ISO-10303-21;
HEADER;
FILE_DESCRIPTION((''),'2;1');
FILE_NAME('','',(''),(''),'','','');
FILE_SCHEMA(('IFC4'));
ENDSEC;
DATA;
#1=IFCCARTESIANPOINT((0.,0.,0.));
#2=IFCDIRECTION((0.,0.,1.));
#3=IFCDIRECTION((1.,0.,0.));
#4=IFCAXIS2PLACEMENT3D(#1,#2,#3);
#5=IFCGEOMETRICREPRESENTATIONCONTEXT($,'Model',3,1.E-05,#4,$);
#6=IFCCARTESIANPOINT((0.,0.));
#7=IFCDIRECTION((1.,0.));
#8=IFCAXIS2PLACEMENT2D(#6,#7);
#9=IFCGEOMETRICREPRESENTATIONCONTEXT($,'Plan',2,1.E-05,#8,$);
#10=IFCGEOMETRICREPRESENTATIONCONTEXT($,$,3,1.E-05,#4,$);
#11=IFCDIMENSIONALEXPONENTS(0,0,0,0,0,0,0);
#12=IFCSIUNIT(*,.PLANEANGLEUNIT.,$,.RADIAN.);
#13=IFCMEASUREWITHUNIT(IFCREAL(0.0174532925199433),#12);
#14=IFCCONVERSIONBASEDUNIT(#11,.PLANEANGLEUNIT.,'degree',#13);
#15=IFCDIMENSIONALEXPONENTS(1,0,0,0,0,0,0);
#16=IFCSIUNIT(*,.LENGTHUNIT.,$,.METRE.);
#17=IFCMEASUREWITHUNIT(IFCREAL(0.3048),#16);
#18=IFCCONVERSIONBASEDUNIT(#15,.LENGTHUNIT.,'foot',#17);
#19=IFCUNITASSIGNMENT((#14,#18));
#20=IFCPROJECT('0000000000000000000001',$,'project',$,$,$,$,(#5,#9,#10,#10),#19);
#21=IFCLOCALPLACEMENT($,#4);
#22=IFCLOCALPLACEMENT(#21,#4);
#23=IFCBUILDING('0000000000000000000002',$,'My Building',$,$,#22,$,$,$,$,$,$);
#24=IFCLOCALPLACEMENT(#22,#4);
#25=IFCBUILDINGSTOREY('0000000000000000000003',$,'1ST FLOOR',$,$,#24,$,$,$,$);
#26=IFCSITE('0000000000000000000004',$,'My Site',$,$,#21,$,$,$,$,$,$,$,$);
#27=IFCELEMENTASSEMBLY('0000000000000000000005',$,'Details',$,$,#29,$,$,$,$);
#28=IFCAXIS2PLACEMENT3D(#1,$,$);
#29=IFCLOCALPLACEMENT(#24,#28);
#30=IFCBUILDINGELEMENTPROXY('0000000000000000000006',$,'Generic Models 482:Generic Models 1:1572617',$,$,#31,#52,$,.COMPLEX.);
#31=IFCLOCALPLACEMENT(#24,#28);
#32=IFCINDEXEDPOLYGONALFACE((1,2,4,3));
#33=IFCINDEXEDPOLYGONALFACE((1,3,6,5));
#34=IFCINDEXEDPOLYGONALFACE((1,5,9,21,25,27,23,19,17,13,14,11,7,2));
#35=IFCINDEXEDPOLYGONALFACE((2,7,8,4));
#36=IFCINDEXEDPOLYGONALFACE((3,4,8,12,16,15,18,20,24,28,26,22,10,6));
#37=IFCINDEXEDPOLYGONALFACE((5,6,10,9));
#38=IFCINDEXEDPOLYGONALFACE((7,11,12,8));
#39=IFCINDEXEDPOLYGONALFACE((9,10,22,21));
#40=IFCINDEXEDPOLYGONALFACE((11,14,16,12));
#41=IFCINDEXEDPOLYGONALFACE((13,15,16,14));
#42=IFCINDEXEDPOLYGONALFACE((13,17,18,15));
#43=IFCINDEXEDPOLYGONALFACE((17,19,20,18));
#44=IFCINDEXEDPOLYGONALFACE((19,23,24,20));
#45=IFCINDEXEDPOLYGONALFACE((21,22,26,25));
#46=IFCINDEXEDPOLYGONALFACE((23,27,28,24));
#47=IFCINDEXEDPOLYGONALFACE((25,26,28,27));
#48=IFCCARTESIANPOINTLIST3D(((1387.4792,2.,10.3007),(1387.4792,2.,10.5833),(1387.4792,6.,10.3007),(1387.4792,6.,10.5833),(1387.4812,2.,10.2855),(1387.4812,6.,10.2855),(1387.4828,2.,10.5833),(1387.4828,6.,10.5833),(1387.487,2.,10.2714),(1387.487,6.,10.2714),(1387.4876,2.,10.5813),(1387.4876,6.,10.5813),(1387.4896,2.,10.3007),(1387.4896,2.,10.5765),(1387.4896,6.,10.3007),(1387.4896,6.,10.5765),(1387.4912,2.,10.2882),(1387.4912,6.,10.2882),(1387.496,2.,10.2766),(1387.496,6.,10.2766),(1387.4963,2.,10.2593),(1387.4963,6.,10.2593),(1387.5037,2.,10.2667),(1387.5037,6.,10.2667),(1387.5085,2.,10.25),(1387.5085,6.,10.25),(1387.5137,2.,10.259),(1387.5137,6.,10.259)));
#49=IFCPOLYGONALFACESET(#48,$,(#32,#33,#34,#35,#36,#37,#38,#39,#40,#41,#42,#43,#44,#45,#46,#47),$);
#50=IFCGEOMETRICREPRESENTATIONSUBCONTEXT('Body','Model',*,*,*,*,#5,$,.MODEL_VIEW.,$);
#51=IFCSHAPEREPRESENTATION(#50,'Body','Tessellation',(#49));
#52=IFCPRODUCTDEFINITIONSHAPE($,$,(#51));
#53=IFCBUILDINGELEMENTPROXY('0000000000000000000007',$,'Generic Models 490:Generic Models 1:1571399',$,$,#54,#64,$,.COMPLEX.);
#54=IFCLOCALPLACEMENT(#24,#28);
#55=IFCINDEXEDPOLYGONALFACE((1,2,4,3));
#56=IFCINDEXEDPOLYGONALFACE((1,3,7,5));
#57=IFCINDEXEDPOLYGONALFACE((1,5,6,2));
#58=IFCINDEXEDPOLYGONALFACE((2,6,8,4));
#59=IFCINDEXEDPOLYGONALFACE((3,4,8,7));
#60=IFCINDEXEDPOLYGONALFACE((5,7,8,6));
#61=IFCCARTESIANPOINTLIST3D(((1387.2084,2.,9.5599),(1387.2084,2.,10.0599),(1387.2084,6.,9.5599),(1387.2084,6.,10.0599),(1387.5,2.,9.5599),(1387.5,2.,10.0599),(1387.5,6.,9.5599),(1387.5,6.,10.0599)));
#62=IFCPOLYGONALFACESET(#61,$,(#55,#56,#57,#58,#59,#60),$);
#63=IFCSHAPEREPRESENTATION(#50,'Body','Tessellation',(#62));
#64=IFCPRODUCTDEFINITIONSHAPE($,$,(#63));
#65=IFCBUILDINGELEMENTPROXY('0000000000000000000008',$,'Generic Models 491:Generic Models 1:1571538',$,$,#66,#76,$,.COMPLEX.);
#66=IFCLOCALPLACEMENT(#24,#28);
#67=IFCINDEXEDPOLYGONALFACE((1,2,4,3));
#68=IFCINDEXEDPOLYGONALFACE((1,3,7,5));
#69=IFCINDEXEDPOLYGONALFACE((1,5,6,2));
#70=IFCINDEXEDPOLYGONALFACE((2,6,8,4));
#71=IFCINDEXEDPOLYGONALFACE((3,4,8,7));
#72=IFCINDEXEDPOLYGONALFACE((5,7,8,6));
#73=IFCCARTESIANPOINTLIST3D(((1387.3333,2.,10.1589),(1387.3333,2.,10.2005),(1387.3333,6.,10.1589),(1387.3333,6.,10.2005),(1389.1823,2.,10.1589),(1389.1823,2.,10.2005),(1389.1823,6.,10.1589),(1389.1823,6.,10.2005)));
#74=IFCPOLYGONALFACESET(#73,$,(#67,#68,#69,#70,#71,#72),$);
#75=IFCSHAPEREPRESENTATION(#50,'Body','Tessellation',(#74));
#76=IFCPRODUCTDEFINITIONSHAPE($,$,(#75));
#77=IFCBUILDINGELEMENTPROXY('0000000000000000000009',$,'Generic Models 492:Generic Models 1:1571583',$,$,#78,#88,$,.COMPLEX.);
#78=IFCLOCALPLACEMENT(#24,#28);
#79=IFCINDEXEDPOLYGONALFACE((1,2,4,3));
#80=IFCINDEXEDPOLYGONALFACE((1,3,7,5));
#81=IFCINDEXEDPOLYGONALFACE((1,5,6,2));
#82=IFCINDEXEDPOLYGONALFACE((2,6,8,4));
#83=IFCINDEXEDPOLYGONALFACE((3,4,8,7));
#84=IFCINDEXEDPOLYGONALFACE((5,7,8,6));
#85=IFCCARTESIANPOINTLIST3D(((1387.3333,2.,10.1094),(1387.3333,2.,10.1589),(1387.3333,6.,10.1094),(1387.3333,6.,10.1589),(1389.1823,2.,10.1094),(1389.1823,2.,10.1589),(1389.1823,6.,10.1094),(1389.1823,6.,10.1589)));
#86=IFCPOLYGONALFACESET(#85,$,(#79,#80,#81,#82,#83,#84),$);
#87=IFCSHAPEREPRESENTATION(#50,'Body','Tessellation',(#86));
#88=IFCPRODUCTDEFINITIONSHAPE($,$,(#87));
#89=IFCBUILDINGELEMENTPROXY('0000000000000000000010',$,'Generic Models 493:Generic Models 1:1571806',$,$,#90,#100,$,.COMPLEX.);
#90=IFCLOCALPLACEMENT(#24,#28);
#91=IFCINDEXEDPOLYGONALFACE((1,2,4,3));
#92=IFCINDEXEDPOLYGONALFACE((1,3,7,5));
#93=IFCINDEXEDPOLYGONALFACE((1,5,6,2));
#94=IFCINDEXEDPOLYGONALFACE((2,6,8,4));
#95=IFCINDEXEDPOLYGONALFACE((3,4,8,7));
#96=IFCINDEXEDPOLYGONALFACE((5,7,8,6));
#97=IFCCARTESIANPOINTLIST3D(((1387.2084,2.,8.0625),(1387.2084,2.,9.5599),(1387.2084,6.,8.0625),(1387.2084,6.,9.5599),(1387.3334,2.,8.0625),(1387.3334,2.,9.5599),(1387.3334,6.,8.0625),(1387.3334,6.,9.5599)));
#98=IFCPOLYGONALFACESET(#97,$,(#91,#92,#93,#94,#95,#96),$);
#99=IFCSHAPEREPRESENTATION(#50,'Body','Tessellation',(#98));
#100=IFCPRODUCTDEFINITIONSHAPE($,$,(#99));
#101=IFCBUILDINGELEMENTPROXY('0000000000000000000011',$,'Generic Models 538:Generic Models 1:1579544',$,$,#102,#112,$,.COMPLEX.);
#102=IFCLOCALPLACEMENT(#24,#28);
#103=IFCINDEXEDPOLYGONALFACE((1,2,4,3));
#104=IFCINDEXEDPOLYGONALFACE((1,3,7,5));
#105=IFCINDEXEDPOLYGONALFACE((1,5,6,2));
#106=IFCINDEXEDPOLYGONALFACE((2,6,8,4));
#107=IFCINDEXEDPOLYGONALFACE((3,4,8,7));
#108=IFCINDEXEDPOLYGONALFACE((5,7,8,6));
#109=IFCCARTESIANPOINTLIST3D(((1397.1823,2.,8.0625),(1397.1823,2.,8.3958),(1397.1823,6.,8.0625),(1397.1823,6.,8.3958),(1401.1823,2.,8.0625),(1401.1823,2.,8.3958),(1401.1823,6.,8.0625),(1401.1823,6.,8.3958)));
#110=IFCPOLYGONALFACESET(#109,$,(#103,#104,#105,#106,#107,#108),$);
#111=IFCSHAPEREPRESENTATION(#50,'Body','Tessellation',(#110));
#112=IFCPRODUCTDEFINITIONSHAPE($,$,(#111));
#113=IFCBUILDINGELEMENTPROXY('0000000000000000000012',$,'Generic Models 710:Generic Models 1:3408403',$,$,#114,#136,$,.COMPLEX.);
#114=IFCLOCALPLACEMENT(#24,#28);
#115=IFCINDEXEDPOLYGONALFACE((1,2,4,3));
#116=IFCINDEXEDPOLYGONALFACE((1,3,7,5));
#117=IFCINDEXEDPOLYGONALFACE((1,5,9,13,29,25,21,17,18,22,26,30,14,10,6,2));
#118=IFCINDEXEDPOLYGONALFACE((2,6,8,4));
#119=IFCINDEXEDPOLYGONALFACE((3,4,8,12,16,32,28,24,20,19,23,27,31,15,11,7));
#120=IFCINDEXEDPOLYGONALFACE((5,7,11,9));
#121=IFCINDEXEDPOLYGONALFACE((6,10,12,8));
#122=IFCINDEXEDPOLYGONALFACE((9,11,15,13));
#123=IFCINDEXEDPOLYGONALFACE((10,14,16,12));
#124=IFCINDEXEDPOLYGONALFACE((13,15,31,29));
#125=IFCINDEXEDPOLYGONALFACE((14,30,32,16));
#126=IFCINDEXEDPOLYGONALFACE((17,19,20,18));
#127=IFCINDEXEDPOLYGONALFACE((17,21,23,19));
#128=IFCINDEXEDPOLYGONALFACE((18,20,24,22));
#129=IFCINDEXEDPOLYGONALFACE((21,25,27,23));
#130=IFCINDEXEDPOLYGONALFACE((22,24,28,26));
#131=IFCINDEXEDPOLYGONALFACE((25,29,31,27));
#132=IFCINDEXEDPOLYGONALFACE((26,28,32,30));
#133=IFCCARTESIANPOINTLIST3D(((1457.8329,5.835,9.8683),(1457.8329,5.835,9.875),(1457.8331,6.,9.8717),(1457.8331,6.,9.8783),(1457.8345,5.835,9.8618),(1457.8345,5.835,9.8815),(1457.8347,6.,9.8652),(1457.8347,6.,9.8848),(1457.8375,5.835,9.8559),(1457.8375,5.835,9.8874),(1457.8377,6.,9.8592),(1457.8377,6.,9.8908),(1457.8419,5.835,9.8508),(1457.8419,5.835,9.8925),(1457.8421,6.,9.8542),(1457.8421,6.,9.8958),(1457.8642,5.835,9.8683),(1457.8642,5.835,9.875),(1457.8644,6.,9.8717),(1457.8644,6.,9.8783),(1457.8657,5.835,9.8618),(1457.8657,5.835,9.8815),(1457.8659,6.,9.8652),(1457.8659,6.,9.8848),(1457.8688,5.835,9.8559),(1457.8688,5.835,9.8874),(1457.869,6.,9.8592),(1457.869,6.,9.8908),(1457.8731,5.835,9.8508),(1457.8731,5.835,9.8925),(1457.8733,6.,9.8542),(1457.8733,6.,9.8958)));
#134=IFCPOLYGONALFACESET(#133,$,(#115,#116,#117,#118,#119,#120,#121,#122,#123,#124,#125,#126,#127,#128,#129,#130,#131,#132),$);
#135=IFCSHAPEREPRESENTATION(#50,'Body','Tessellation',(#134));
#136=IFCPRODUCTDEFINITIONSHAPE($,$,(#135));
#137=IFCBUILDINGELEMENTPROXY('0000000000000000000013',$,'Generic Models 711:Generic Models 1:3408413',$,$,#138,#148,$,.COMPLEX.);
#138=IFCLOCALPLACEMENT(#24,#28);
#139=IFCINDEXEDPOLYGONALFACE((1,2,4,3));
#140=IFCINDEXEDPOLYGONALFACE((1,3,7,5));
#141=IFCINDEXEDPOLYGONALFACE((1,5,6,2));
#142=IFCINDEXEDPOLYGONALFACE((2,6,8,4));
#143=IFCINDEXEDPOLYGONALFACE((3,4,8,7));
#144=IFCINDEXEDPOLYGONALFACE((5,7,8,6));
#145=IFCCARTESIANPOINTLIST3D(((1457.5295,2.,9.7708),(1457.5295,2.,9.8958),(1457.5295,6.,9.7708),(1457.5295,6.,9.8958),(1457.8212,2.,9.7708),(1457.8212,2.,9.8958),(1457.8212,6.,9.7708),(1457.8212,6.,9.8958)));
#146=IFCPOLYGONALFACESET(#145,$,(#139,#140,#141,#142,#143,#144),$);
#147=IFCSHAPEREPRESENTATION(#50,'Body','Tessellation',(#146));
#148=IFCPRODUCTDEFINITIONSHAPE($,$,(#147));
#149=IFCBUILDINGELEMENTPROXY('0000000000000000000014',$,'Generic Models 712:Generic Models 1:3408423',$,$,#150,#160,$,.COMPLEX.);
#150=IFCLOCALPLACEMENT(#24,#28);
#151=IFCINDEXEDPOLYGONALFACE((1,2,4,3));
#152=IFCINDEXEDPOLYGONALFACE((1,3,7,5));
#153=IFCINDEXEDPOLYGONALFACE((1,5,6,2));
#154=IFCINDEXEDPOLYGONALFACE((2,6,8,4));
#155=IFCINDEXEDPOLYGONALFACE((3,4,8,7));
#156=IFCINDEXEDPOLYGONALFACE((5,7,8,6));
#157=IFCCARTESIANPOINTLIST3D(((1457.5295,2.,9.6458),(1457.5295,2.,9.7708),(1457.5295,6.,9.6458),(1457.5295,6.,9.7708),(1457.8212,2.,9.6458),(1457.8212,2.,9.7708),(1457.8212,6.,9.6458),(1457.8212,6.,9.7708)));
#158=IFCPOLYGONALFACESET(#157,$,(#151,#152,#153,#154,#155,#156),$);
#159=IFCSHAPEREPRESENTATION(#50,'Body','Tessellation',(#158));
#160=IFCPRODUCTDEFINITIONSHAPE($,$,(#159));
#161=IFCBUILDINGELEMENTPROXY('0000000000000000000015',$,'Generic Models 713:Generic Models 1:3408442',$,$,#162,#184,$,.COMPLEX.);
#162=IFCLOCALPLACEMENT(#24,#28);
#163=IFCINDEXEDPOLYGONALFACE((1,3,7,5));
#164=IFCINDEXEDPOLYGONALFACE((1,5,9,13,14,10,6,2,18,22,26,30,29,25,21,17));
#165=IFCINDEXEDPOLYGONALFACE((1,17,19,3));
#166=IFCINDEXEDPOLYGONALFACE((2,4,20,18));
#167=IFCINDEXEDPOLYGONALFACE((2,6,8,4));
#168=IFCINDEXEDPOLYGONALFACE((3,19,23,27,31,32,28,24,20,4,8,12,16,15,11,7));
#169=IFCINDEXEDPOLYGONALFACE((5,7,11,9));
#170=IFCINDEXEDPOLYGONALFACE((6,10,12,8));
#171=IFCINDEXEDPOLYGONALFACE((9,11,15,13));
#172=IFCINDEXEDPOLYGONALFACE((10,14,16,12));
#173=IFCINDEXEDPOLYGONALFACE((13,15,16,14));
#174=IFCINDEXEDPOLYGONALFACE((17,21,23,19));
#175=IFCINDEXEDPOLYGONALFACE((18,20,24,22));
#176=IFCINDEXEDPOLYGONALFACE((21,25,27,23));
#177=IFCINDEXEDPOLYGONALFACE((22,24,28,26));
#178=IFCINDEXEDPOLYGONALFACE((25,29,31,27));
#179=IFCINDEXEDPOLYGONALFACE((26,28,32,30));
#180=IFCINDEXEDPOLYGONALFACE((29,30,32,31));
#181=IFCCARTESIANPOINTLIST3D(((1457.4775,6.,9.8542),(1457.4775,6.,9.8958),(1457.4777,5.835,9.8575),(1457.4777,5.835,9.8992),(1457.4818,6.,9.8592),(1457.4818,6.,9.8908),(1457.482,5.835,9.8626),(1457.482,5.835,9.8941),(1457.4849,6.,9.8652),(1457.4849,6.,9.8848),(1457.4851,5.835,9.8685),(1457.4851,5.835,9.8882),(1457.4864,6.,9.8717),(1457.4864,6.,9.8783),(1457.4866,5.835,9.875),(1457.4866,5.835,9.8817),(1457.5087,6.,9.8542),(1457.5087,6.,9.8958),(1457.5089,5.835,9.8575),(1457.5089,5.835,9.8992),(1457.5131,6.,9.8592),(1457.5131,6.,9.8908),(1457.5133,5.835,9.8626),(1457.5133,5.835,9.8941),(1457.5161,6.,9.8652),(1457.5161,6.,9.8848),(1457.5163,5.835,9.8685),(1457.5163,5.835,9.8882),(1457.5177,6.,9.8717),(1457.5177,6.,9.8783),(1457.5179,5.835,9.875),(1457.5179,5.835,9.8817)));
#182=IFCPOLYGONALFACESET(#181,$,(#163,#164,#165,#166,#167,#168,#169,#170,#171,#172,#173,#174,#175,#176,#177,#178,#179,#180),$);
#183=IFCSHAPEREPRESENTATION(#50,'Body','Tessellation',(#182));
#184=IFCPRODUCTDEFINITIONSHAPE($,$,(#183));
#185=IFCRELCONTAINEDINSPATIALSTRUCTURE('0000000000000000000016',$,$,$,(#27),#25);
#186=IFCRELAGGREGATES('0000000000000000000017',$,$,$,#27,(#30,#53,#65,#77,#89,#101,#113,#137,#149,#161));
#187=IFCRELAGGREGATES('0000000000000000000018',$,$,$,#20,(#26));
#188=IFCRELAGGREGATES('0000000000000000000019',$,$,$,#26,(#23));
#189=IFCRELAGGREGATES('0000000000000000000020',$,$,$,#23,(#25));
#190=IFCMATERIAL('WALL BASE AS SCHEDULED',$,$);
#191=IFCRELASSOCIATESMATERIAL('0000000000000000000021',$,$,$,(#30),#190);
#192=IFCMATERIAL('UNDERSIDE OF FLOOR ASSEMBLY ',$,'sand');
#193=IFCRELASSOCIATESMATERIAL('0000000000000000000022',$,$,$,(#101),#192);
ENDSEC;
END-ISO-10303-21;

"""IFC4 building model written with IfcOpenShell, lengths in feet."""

from ifc_helpers import new_model, entity, si_unit, converted_unit, frame, origin_with_axes, origin_2d_with_axis, place, context, subcontext, project, spatial, polyline, outline, extrude, material, element, aggregate, save


model = new_model("IFC4")

# Units and contexts
model_context = context("Model", 3, precision=1e-05, world=origin_with_axes())
plan_context = context("Plan", 2, precision=1e-05, world=origin_2d_with_axis())
context_of_model = context(None, 3, precision=1e-05, world=origin_with_axes())
body_context = subcontext(model_context, "Body", "Model", "MODEL_VIEW")
ifc_project = project(units=[converted_unit("PLANEANGLEUNIT", "degree", entity("IfcReal", 0.0174532925199433), si_unit("PLANEANGLEUNIT", "RADIAN"), dimensions=[0, 0, 0, 0, 0, 0, 0]), converted_unit("LENGTHUNIT", "foot", entity("IfcReal", 0.3048), si_unit("LENGTHUNIT", "METRE"), dimensions=[1, 0, 0, 0, 0, 0, 0])], contexts=[model_context, plan_context, context_of_model, context_of_model])

# Site, building, storey
site_placement = place(None, origin_with_axes())
site = spatial("IfcSite", under=ifc_project, at=site_placement, Name="My Site")
building_placement = place(site_placement, origin_with_axes())
building = spatial("IfcBuilding", under=site, at=building_placement, Name="My Building")
storey_placement = place(building_placement, origin_with_axes())
storey = spatial("IfcBuildingStorey", under=building, at=storey_placement, Name="1ST FLOOR")

# Element assembly, building element proxies
assembly_placement = place(storey_placement, origin_with_axes())
assembly = element("IfcElementAssembly", 1, at=assembly_placement, inside=storey, Name="Details")
ifc_material_1 = material(Name="WALL BASE AS SCHEDULED")
proxy_1_placement = place(assembly_placement, frame((1387.4792, 6.0, 10.25), z_axis=(0.0, -1.0, 0.0), x_axis=(0.0, 0.0, 1.0)))
proxy_1 = element("IfcBuildingElementProxy", 2, at=proxy_1_placement, material=ifc_material_1, Name="Generic Models 482:Generic Models 1:1572617", PredefinedType="COMPLEX", context=body_context, shape_type="SweptSolid", body=[
    extrude(outline(polyline([(0.2206, 0.0), (0.2204, 0.0036), (0.2182, 0.0083), (0.2132, 0.01), (-0.0621, -0.0058), (-0.0747, -0.0049), (-0.0865, -0.0007), (-0.0969, 0.0063), (-0.1051, 0.0158), (-0.1138, 0.0101), (-0.1038, -0.0014), (-0.0912, -0.01), (-0.0768, -0.0151), (-0.0615, -0.0162), (0.2206, 0.0)])), frame((0.113, -0.0126, 0.0), z_axis=(0.0, 0.0, -1.0), x_axis=(0.998358, 0.057286, 0.0)), (0.0, 0.0, -1.0), 4.0),
])
proxy_2_placement = place(assembly_placement, frame((1387.2084, 6.0, 9.5599), z_axis=(0.0, -1.0, 0.0), x_axis=(0.0, 0.0, 1.0)))
proxy_2 = element("IfcBuildingElementProxy", 3, at=proxy_2_placement, Name="Generic Models 490:Generic Models 1:1571399", PredefinedType="COMPLEX", context=body_context, shape_type="SweptSolid", body=[
    extrude(outline(polyline([(-0.25, -0.1458), (0.25, -0.1458), (0.25, 0.1458), (-0.25, 0.1458), (-0.25, -0.1458)])), frame((0.25, -0.1458, 0.0), z_axis=(0.0, 0.0, -1.0), x_axis=(-1.0, 0.0, 0.0)), (0.0, 0.0, -1.0), 4.0),
])
proxy_3_placement = place(assembly_placement, frame((1387.3333, 6.0, 10.1589), z_axis=(0.0, -1.0, 0.0), x_axis=(0.0, 0.0, 1.0)))
proxy_3 = element("IfcBuildingElementProxy", 4, at=proxy_3_placement, Name="Generic Models 491:Generic Models 1:1571538", PredefinedType="COMPLEX", context=body_context, shape_type="SweptSolid", body=[
    extrude(outline(polyline([(-0.0208, -0.9245), (0.0208, -0.9245), (0.0208, 0.9245), (-0.0208, 0.9245), (-0.0208, -0.9245)])), frame((0.0208, -0.9245, 0.0), z_axis=(0.0, 0.0, -1.0), x_axis=(-1.0, 0.0, 0.0)), (0.0, 0.0, -1.0), 4.0),
])
proxy_4_placement = place(assembly_placement, frame((1387.3333, 6.0, 10.1094), z_axis=(0.0, -1.0, 0.0), x_axis=(0.0, 0.0, 1.0)))
proxy_4 = element("IfcBuildingElementProxy", 5, at=proxy_4_placement, Name="Generic Models 492:Generic Models 1:1571583", PredefinedType="COMPLEX", context=body_context, shape_type="SweptSolid", body=[
    extrude(outline(polyline([(-0.0247, -0.9245), (0.0247, -0.9245), (0.0247, 0.9245), (-0.0247, 0.9245), (-0.0247, -0.9245)])), frame((0.0247, -0.9245, 0.0), z_axis=(0.0, 0.0, -1.0), x_axis=(-1.0, 0.0, 0.0)), (0.0, 0.0, -1.0), 4.0),
])
proxy_5_placement = place(assembly_placement, frame((1387.2084, 6.0, 8.0625), z_axis=(0.0, -1.0, 0.0), x_axis=(0.0, 0.0, 1.0)))
proxy_5 = element("IfcBuildingElementProxy", 6, at=proxy_5_placement, Name="Generic Models 493:Generic Models 1:1571806", PredefinedType="COMPLEX", context=body_context, shape_type="SweptSolid", body=[
    extrude(outline(polyline([(-0.7487, -0.0625), (0.7487, -0.0625), (0.7487, 0.0625), (-0.7487, 0.0625), (-0.7487, -0.0625)])), frame((0.7487, -0.0625, 0.0), z_axis=(0.0, 0.0, -1.0), x_axis=(-1.0, 0.0, 0.0)), (0.0, 0.0, -1.0), 4.0),
])
ifc_material_2 = material(Name="UNDERSIDE OF FLOOR ASSEMBLY ", Category="sand")
proxy_6_placement = place(assembly_placement, frame((1397.1823, 6.0, 8.0625), z_axis=(0.0, -1.0, 0.0), x_axis=(0.0, 0.0, 1.0)))
proxy_6 = element("IfcBuildingElementProxy", 7, at=proxy_6_placement, material=ifc_material_2, Name="Generic Models 538:Generic Models 1:1579544", PredefinedType="COMPLEX", context=body_context, shape_type="SweptSolid", body=[
    extrude(outline(polyline([(-0.1667, -2.0), (0.1667, -2.0), (0.1667, 2.0), (-0.1667, 2.0), (-0.1667, -2.0)])), frame((0.1667, -2.0, 0.0), z_axis=(0.0, 0.0, -1.0), x_axis=(1.0, 0.0, 0.0)), (0.0, 0.0, -1.0), 4.0),
])
proxy_7_placement = place(assembly_placement, frame((1457.8331, 6.0, 9.8542), z_axis=(0.0, -1.0, 0.0), x_axis=(0.0, 0.0, 1.0)))
proxy_7 = element("IfcBuildingElementProxy", 8, at=proxy_7_placement, Name="Generic Models 710:Generic Models 1:3408403", PredefinedType="COMPLEX", context=body_context, shape_type="SweptSolid", body=[
    extrude(outline(polyline([(0.0166, 0.0), (0.0115, 0.0043), (0.0076, 0.0097), (0.005, 0.0159), (0.0039, 0.0224), (0.0045, 0.0291), (-0.0207, 0.0106), (-0.0213, 0.004), (-0.0202, -0.0026), (-0.0176, -0.0088), (-0.0137, -0.0142), (-0.0086, -0.0185), (-0.0026, -0.0215), (0.0039, -0.023), (0.0291, -0.0045), (0.0226, -0.003), (0.0166, 0.0)])), frame((0.0208, -0.0194, 0.0), z_axis=(0.0, 0.0, -1.0), x_axis=(0.591192, -0.806531, 0.0)), (-0.012926, 0.015608, -0.999795), 0.165),
])
proxy_8_placement = place(assembly_placement, frame((1457.5295, 6.0, 9.7708), z_axis=(0.0, -1.0, 0.0), x_axis=(0.0, 0.0, 1.0)))
proxy_8 = element("IfcBuildingElementProxy", 9, at=proxy_8_placement, Name="Generic Models 711:Generic Models 1:3408413", PredefinedType="COMPLEX", context=body_context, shape_type="SweptSolid", body=[
    extrude(outline(polyline([(-0.0625, -0.1458), (0.0625, -0.1458), (0.0625, 0.1458), (-0.0625, 0.1458), (-0.0625, -0.1458)])), frame((0.0625, -0.1458, 0.0), z_axis=(0.0, 0.0, -1.0), x_axis=(-1.0, 0.0, 0.0)), (0.0, 0.0, -1.0), 4.0),
])
proxy_9_placement = place(assembly_placement, frame((1457.5295, 6.0, 9.6458), z_axis=(0.0, -1.0, 0.0), x_axis=(0.0, 0.0, 1.0)))
proxy_9 = element("IfcBuildingElementProxy", 10, at=proxy_9_placement, Name="Generic Models 712:Generic Models 1:3408423", PredefinedType="COMPLEX", context=body_context, shape_type="SweptSolid", body=[
    extrude(outline(polyline([(-0.0625, -0.1458), (0.0625, -0.1458), (0.0625, 0.1458), (-0.0625, 0.1458), (-0.0625, -0.1458)])), frame((0.0625, -0.1458, 0.0), z_axis=(0.0, 0.0, -1.0), x_axis=(1.0, 0.0, 0.0)), (0.0, 0.0, -1.0), 4.0),
])
proxy_10_placement = place(assembly_placement, frame((1457.4775, 6.0, 9.8542), z_axis=(0.0, -1.0, 0.0), x_axis=(0.0, 0.0, 1.0)))
proxy_10 = element("IfcBuildingElementProxy", 11, at=proxy_10_placement, Name="Generic Models 713:Generic Models 1:3408442", PredefinedType="COMPLEX", context=body_context, shape_type="SweptSolid", body=[
    extrude(outline(polyline([(0.0166, 0.0), (0.0226, 0.003), (0.0291, 0.0045), (0.0039, 0.023), (-0.0026, 0.0215), (-0.0086, 0.0185), (-0.0137, 0.0142), (-0.0176, 0.0088), (-0.0202, 0.0026), (-0.0213, -0.004), (-0.0207, -0.0106), (0.0045, -0.0291), (0.0039, -0.0224), (0.005, -0.0159), (0.0076, -0.0097), (0.0115, -0.0043), (0.0166, 0.0)])), frame((0.0208, -0.0208, 0.0), z_axis=(0.0, 0.0, -1.0), x_axis=(0.591192, 0.806531, 0.0)), (0.010994, 0.017024, -0.999795), 0.165),
])
aggregate(assembly, [proxy_1, proxy_2, proxy_3, proxy_4, proxy_5, proxy_6, proxy_7, proxy_8, proxy_9, proxy_10])

save(model, "model.ifc")
